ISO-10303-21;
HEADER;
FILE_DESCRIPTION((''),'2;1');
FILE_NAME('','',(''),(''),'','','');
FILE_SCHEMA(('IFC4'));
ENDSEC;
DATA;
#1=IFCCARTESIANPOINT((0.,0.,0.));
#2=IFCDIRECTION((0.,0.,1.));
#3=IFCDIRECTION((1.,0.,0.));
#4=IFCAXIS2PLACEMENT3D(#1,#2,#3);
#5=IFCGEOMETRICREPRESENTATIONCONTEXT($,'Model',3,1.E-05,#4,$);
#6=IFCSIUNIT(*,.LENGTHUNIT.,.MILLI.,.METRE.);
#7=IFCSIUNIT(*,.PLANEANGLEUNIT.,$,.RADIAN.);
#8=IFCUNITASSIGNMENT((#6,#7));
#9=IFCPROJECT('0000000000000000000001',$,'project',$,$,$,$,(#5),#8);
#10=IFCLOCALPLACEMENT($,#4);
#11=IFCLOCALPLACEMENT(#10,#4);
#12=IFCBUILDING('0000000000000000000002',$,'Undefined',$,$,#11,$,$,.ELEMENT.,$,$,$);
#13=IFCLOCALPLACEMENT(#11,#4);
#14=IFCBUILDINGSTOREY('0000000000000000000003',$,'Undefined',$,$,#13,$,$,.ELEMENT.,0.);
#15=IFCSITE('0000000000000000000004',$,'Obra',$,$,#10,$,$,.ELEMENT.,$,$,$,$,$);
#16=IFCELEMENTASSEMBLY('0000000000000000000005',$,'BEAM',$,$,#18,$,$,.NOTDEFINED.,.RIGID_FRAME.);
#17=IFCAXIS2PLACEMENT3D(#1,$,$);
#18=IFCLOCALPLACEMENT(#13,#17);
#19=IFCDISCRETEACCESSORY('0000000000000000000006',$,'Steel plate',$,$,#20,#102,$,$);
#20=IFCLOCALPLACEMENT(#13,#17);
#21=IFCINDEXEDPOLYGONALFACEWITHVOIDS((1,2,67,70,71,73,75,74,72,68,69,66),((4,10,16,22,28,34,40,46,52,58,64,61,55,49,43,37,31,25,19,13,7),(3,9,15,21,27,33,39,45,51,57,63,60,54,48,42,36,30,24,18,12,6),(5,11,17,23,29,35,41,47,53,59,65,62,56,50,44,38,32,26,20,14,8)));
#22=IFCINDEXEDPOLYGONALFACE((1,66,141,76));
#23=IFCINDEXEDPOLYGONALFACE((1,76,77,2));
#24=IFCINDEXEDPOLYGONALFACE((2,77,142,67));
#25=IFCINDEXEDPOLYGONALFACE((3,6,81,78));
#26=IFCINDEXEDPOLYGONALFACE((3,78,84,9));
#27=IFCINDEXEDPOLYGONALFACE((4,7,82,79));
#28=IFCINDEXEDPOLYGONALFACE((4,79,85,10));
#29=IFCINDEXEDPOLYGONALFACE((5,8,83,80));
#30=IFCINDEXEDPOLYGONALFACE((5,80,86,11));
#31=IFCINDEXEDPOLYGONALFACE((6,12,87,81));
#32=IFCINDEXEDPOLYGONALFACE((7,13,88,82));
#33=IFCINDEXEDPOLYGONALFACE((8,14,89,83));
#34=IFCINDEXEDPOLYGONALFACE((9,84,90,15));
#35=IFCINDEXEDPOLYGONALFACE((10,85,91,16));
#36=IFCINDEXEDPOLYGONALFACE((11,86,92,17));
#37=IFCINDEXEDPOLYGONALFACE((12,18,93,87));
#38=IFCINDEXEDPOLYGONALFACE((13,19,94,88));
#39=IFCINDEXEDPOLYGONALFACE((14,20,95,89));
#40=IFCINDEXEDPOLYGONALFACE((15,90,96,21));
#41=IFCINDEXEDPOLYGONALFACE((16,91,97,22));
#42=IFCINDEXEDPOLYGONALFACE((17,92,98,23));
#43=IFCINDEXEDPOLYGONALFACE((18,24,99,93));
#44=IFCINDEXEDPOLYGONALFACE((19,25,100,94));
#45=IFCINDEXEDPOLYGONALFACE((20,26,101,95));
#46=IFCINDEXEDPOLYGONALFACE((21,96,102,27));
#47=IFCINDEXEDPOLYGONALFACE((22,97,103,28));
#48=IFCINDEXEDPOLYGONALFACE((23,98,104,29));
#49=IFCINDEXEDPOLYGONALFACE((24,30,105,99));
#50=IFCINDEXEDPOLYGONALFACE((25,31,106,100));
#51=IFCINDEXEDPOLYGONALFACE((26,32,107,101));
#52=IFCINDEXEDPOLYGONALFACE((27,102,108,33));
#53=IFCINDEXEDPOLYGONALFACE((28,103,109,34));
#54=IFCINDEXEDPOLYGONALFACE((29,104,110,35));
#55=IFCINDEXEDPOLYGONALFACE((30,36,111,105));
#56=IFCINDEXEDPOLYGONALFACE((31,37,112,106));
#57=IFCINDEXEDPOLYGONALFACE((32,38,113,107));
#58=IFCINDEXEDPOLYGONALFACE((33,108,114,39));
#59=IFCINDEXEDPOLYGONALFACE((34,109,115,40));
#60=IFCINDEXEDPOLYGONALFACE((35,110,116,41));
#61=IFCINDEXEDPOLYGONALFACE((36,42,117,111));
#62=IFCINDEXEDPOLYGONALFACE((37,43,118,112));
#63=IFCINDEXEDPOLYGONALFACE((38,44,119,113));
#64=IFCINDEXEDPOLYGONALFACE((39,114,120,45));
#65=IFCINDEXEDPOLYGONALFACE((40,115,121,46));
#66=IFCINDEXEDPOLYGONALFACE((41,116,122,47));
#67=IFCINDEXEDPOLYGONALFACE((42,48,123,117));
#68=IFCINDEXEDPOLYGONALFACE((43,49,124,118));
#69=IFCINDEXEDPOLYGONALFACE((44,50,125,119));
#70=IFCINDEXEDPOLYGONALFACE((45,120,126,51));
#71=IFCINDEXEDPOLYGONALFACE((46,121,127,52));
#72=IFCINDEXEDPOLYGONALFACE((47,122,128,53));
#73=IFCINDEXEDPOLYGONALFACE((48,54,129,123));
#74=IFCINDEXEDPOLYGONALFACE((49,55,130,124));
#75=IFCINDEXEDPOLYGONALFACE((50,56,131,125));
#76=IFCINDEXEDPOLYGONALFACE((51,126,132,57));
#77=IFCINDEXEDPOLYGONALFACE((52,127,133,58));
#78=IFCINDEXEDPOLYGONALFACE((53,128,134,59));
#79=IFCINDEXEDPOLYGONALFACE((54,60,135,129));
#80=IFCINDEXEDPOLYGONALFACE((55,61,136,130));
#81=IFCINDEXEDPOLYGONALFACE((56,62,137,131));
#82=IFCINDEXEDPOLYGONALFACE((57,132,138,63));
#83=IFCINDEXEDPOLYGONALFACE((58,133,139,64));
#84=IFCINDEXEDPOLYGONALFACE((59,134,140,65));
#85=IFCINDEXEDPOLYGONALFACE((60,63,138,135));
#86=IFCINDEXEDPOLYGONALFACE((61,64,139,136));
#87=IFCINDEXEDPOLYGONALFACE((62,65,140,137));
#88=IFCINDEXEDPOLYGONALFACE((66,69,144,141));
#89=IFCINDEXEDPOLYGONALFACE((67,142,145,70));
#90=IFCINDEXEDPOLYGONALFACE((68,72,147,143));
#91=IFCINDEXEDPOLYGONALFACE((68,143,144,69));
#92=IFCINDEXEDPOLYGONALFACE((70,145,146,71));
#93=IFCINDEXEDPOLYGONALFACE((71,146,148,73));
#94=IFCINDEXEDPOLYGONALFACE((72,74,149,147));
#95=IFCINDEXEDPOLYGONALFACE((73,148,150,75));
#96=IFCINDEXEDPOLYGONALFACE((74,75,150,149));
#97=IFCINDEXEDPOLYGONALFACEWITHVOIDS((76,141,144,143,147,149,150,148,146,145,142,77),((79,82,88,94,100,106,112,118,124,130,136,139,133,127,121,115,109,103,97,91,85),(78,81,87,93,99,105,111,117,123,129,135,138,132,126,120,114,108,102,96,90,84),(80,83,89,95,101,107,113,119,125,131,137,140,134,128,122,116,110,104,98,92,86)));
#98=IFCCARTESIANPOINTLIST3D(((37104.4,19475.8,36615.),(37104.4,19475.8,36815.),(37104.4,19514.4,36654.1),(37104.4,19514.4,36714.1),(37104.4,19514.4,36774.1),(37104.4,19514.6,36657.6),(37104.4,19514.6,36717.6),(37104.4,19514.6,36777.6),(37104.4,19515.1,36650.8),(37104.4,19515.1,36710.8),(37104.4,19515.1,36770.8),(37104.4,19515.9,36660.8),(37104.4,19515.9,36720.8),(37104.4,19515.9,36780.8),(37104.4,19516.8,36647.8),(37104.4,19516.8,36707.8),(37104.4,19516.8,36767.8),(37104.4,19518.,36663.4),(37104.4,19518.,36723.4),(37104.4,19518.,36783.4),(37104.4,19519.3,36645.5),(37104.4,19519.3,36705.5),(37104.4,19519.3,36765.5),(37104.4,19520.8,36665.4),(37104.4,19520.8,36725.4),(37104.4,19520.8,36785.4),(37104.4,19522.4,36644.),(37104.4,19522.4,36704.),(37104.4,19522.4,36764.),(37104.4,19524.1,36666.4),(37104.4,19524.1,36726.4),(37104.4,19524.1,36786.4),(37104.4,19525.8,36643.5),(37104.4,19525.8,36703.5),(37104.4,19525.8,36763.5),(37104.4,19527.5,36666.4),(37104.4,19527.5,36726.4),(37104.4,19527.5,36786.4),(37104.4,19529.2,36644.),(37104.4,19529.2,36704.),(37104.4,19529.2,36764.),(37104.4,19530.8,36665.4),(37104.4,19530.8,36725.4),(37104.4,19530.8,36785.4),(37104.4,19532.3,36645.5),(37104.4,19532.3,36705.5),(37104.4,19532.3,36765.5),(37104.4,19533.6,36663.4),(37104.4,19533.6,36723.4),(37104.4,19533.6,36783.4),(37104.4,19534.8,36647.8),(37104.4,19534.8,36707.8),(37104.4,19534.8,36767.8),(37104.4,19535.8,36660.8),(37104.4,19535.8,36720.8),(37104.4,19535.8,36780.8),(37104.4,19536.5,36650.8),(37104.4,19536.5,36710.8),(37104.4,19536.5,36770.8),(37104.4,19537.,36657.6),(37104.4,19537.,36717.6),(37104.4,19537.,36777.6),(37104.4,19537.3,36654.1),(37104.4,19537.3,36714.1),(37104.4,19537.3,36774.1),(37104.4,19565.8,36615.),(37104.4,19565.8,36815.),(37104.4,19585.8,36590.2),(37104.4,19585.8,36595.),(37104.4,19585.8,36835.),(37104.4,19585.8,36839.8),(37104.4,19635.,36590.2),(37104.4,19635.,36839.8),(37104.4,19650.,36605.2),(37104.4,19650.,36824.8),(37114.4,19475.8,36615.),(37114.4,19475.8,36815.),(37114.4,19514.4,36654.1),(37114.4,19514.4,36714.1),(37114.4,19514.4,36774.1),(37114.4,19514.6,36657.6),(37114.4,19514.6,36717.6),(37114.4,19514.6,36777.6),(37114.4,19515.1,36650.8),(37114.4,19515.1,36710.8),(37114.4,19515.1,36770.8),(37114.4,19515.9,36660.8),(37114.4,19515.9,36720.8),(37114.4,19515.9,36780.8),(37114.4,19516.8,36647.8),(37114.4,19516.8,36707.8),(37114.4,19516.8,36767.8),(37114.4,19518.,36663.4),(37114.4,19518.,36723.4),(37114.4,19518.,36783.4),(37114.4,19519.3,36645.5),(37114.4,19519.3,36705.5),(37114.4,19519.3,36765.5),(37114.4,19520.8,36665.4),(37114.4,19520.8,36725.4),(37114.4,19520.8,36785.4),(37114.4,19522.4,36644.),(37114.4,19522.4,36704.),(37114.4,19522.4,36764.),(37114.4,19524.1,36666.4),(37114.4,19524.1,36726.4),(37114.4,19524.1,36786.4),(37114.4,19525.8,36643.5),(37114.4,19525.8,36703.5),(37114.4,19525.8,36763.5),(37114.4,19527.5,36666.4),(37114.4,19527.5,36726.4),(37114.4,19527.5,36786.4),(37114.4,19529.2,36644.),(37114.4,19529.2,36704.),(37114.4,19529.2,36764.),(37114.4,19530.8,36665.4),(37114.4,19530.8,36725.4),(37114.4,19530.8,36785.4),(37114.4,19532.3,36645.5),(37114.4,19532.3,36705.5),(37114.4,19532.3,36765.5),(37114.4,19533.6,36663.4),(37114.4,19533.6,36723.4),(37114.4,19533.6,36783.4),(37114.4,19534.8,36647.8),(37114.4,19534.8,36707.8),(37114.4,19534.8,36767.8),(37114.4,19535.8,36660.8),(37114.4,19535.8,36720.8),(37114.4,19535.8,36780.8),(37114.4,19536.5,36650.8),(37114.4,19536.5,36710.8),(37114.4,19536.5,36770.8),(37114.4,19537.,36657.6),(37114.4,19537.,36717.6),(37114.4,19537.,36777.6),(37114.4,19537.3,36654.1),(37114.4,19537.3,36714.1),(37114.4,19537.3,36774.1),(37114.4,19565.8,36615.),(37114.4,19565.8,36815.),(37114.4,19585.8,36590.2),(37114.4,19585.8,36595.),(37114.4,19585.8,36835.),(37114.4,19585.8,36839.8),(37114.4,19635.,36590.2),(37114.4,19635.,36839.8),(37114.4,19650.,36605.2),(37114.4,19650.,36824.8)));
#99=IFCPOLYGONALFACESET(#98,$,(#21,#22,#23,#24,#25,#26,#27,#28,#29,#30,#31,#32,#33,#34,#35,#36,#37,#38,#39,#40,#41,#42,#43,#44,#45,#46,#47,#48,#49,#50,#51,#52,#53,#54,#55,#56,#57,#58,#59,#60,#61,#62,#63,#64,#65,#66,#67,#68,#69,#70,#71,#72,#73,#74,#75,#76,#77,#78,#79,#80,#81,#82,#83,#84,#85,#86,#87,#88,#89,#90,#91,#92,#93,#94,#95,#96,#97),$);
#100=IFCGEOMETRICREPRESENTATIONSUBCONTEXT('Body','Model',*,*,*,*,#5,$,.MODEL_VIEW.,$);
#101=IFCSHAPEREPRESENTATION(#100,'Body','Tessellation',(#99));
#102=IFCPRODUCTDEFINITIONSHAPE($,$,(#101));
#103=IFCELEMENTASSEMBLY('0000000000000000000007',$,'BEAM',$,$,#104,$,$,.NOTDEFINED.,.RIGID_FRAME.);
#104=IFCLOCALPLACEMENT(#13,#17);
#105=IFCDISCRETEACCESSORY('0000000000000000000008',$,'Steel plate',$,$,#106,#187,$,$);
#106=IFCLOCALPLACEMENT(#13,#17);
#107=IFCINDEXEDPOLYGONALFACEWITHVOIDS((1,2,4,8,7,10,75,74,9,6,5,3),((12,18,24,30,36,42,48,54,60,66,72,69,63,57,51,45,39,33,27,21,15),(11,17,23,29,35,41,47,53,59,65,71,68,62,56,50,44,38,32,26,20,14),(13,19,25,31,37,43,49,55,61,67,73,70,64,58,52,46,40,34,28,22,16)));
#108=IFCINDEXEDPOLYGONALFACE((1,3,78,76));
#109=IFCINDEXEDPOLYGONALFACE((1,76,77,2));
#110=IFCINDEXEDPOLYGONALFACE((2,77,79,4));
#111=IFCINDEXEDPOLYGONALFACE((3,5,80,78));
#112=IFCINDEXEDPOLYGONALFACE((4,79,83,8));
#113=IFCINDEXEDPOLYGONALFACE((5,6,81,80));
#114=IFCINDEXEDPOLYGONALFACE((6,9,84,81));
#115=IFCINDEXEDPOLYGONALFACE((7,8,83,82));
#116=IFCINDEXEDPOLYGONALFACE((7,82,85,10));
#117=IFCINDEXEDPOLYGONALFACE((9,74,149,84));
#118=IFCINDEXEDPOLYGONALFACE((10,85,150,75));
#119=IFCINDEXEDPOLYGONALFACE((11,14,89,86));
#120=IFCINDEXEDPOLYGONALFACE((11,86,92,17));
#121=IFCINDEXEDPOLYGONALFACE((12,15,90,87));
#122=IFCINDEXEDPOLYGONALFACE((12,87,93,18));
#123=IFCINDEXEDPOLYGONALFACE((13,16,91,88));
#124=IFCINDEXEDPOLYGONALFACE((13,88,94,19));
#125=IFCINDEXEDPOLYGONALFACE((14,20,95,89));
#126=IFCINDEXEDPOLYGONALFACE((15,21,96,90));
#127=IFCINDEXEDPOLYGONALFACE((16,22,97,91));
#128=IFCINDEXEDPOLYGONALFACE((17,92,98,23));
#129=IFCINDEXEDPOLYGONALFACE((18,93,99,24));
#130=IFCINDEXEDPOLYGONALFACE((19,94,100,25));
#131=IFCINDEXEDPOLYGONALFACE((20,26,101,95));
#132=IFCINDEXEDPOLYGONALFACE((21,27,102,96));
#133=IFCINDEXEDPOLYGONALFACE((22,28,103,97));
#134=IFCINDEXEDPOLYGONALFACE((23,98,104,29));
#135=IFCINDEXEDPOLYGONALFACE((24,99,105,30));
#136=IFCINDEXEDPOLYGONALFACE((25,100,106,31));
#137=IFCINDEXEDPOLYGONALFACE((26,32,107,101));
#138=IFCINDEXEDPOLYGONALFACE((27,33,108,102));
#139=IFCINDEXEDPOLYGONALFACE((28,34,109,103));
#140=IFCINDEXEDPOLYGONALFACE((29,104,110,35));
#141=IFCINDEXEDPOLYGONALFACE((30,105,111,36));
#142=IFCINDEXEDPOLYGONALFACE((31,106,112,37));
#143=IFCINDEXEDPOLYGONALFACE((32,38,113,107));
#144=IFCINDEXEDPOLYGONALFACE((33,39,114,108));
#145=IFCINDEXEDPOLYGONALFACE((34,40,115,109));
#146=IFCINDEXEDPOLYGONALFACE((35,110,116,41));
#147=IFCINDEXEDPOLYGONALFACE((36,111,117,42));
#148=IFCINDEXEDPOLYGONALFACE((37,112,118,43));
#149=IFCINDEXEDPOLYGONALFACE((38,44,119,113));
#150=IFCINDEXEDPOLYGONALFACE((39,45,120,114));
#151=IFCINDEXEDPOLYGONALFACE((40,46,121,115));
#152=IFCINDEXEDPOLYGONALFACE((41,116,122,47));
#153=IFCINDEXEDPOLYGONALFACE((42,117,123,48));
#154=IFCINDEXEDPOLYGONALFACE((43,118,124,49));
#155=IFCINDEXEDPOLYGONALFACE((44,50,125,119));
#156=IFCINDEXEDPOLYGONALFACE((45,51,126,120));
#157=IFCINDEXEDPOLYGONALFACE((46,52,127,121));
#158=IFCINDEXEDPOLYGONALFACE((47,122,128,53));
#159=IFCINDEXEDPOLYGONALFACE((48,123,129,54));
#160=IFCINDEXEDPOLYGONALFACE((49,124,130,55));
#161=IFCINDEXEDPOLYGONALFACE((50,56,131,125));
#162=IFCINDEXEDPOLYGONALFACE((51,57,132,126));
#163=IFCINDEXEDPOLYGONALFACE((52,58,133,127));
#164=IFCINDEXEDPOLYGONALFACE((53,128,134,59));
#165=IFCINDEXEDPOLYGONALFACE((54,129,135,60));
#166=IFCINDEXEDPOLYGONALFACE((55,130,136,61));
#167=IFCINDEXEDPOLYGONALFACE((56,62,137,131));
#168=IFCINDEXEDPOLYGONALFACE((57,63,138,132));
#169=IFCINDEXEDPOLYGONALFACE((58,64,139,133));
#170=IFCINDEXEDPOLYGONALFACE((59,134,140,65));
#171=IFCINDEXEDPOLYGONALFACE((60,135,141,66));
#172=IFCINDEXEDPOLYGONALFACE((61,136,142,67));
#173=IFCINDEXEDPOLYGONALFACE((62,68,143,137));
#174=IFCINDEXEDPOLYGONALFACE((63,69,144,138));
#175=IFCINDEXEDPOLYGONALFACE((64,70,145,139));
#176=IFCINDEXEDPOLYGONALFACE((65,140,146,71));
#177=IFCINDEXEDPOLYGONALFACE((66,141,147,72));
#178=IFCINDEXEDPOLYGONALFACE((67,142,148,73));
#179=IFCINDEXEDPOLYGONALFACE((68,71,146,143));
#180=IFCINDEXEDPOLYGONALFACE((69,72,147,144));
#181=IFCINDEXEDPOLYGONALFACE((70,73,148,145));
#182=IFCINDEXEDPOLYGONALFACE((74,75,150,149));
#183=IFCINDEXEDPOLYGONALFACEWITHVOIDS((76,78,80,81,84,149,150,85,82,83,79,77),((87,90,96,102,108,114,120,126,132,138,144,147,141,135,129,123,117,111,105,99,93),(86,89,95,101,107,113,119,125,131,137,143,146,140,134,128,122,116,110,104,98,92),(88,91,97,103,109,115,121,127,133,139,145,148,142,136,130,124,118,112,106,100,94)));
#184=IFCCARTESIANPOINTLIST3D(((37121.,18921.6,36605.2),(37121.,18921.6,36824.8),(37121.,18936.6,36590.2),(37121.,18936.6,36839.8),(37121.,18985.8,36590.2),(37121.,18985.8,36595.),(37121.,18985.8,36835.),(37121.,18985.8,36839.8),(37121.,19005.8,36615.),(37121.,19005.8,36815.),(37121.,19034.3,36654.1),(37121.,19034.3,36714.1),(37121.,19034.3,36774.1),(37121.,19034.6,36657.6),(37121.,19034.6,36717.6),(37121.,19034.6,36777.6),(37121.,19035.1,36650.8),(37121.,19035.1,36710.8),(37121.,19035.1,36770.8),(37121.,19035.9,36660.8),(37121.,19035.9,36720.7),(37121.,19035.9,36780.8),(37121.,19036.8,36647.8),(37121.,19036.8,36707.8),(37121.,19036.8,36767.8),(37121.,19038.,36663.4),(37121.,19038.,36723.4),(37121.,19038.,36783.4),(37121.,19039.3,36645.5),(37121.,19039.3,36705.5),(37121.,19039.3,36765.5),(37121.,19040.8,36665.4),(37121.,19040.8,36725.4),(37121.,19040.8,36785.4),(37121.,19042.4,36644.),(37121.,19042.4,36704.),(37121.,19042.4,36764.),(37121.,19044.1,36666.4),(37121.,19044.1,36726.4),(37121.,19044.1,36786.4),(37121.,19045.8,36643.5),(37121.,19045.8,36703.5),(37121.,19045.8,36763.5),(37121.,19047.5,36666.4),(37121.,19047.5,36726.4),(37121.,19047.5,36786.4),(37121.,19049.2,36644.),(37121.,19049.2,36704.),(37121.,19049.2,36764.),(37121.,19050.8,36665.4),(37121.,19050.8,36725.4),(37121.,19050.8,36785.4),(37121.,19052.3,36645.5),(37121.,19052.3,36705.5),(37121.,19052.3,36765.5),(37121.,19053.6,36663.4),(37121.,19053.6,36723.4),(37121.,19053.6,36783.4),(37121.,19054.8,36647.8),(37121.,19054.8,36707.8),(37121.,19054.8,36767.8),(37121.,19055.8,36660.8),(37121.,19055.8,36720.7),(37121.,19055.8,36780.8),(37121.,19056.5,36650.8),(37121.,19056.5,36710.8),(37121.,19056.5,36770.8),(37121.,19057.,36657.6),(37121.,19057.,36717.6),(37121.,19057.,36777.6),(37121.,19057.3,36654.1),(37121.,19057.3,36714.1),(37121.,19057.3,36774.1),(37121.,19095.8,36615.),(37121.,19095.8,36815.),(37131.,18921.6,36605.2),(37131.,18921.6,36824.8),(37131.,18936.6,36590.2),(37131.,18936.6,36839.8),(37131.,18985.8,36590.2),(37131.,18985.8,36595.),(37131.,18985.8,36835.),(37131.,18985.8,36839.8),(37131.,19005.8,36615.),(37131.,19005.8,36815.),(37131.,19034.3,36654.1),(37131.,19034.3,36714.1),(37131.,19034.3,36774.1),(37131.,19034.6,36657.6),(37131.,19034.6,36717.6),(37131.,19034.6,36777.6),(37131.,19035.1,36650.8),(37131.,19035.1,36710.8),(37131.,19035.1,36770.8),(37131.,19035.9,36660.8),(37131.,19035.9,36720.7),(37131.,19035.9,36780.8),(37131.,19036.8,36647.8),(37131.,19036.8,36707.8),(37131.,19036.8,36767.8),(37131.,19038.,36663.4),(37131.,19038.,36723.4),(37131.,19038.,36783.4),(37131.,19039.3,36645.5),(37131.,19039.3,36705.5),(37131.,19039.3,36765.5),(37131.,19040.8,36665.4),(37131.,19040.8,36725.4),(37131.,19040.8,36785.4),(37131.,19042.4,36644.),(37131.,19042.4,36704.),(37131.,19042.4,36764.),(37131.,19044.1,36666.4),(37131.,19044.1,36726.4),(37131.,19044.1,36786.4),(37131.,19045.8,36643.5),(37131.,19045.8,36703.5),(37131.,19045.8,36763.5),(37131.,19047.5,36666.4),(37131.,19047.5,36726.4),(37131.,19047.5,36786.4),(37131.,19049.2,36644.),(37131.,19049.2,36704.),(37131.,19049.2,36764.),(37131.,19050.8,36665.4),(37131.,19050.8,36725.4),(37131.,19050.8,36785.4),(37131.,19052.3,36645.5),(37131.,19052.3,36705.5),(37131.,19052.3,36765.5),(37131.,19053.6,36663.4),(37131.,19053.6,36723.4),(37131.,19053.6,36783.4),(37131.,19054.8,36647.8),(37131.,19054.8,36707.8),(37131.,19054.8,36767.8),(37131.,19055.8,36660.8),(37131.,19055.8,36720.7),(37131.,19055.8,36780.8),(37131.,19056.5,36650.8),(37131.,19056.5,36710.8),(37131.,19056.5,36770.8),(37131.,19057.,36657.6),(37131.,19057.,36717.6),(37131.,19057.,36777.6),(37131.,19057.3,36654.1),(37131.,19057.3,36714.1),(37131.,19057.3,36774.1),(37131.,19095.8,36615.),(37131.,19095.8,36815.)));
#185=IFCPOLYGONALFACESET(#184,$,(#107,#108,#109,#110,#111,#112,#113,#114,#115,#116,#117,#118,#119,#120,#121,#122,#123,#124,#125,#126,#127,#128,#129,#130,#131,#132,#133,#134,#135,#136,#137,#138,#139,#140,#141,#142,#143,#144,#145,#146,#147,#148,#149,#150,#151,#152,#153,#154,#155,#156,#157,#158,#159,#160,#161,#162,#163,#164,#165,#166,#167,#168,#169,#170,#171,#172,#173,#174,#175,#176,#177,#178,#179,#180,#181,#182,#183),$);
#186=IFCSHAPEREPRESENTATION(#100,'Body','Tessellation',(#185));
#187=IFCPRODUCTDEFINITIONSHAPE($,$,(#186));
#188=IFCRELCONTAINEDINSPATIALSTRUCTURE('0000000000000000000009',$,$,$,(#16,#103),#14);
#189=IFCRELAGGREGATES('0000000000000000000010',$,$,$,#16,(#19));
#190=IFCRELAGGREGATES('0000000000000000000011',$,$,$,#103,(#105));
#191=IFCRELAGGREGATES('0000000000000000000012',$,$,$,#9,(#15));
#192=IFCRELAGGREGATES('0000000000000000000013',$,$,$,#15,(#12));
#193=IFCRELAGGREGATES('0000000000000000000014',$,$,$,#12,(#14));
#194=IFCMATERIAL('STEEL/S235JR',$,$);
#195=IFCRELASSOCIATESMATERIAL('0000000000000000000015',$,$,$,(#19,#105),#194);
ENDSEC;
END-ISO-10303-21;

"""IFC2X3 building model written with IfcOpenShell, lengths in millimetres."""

from ifc_helpers import new_model, si_unit, frame, origin_with_axes, origin_2d_with_axis, place, context, subcontext, project, spatial, polyline, circle, outline, extrude, source, transform, mapped, material, element, aggregate, save


model = new_model("IFC2X3")

# Units and contexts
model_context = context("Model", 3, precision=1e-05, world=origin_with_axes())
body_context = subcontext(model_context, "Body", "Model", "MODEL_VIEW")
ifc_project = project(units=[si_unit("LENGTHUNIT", "METRE", prefix="MILLI"), si_unit("PLANEANGLEUNIT", "RADIAN")], contexts=[model_context])

# Site, building, storey
site_placement = place(None, origin_with_axes())
site = spatial("IfcSite", under=ifc_project, at=site_placement, Name="Obra", CompositionType="ELEMENT")
building_placement = place(site_placement, origin_with_axes())
building = spatial("IfcBuilding", under=site, at=building_placement, Name="Undefined", CompositionType="ELEMENT")
storey_placement = place(building_placement, origin_with_axes())
storey = spatial("IfcBuildingStorey", under=building, at=storey_placement, Name="Undefined", CompositionType="ELEMENT", Elevation=0.0)

# Shared definitions
ifc_material_1 = material(Name="STEEL/S235JR")

# Element assemblies, discrete accessories, openings
shared_shape_1 = source(origin_with_axes(), body_context, "Body", "SweptSolid", [
    extrude(circle(Radius=11.5, at=origin_2d_with_axis()), frame((0.0, -13.4, 0.0), z_axis=(0.0, 1.0, 0.0), x_axis=(1.0, 0.0, 0.0)), (0.0, 0.0, 1.0), 10.2),
])
assembly_1_placement = place(storey_placement, origin_with_axes())
assembly_1 = element("IfcElementAssembly", 1, at=assembly_1_placement, inside=storey, Name="BEAM", AssemblyPlace="NOTDEFINED", PredefinedType="RIGID_FRAME")
discrete_accessory_1_placement = place(assembly_1_placement, frame((37109.4, 19650.0, 36605.2), z_axis=(-1.0, 0.0, 0.0), x_axis=(0.0, -0.707107, -0.707107)))
discrete_accessory_1 = element("IfcDiscreteAccessory", 2, at=discrete_accessory_1_placement, material=ifc_material_1, Name="Steel plate", context=body_context, shape_type="SweptSolid", body=[
    extrude(outline(polyline([(0.0, 0.0), (21.2, 0.0), (56.0, 34.8), (52.6, 38.2), (52.6, 66.5), (116.2, 130.1), (-25.2, 271.5), (-88.8, 207.9), (-117.1, 207.9), (-120.5, 211.3), (-155.3, 176.5), (-155.3, 155.3), (0.0, 0.0)])), frame((0.0, 0.0, -5.0), z_axis=(0.0, 0.0, 1.0), x_axis=(1.0, 0.0, 0.0)), (0.0, 0.0, 1.0), 10.0),
])
opening_1_placement = place(assembly_1_placement, frame((37117.7, 19575.8, 36815.0), z_axis=(0.0, -1.0, 0.0), x_axis=(0.0, 0.0, -1.0)))
element("IfcOpeningElement", 3, at=opening_1_placement, cuts=discrete_accessory_1, ObjectType="Opening", context=body_context, shape_type="MappedRepresentation", body=[
    mapped(shared_shape_1, transform((40.0, 0.0, 50.0))),
    mapped(shared_shape_1, transform((100.0, 0.0, 50.0))),
    mapped(shared_shape_1, transform((160.0, 0.0, 50.0))),
])
aggregate(assembly_1, [discrete_accessory_1])
assembly_2_placement = place(storey_placement, origin_with_axes())
assembly_2 = element("IfcElementAssembly", 4, at=assembly_2_placement, inside=storey, Name="BEAM", AssemblyPlace="NOTDEFINED", PredefinedType="RIGID_FRAME")
discrete_accessory_2_placement = place(assembly_2_placement, frame((37126.0, 18921.6, 36605.2), z_axis=(1.0, 0.0, 0.0), x_axis=(0.0, 0.707107, -0.707107)))
discrete_accessory_2 = element("IfcDiscreteAccessory", 5, at=discrete_accessory_2_placement, material=ifc_material_1, Name="Steel plate", context=body_context, shape_type="SweptSolid", body=[
    extrude(outline(polyline([(0.0, 0.0), (21.2, 0.0), (56.0, 34.8), (52.6, 38.2), (52.6, 66.5), (116.2, 130.1), (-25.2, 271.5), (-88.8, 207.9), (-117.1, 207.9), (-120.5, 211.3), (-155.3, 176.5), (-155.3, 155.3), (0.0, 0.0)])), frame((0.0, 0.0, -5.0), z_axis=(0.0, 0.0, 1.0), x_axis=(1.0, 0.0, 0.0)), (0.0, 0.0, 1.0), 10.0),
])
opening_2_placement = place(assembly_2_placement, frame((37117.7, 18995.8, 36815.0), z_axis=(0.0, 1.0, 0.0), x_axis=(0.0, 0.0, -1.0)))
element("IfcOpeningElement", 6, at=opening_2_placement, cuts=discrete_accessory_2, ObjectType="Opening", context=body_context, shape_type="MappedRepresentation", body=[
    mapped(shared_shape_1, transform((40.0, 0.0, 50.0))),
    mapped(shared_shape_1, transform((100.0, 0.0, 50.0))),
    mapped(shared_shape_1, transform((160.0, 0.0, 50.0))),
])
aggregate(assembly_2, [discrete_accessory_2])

save(model, "model.ifc")
